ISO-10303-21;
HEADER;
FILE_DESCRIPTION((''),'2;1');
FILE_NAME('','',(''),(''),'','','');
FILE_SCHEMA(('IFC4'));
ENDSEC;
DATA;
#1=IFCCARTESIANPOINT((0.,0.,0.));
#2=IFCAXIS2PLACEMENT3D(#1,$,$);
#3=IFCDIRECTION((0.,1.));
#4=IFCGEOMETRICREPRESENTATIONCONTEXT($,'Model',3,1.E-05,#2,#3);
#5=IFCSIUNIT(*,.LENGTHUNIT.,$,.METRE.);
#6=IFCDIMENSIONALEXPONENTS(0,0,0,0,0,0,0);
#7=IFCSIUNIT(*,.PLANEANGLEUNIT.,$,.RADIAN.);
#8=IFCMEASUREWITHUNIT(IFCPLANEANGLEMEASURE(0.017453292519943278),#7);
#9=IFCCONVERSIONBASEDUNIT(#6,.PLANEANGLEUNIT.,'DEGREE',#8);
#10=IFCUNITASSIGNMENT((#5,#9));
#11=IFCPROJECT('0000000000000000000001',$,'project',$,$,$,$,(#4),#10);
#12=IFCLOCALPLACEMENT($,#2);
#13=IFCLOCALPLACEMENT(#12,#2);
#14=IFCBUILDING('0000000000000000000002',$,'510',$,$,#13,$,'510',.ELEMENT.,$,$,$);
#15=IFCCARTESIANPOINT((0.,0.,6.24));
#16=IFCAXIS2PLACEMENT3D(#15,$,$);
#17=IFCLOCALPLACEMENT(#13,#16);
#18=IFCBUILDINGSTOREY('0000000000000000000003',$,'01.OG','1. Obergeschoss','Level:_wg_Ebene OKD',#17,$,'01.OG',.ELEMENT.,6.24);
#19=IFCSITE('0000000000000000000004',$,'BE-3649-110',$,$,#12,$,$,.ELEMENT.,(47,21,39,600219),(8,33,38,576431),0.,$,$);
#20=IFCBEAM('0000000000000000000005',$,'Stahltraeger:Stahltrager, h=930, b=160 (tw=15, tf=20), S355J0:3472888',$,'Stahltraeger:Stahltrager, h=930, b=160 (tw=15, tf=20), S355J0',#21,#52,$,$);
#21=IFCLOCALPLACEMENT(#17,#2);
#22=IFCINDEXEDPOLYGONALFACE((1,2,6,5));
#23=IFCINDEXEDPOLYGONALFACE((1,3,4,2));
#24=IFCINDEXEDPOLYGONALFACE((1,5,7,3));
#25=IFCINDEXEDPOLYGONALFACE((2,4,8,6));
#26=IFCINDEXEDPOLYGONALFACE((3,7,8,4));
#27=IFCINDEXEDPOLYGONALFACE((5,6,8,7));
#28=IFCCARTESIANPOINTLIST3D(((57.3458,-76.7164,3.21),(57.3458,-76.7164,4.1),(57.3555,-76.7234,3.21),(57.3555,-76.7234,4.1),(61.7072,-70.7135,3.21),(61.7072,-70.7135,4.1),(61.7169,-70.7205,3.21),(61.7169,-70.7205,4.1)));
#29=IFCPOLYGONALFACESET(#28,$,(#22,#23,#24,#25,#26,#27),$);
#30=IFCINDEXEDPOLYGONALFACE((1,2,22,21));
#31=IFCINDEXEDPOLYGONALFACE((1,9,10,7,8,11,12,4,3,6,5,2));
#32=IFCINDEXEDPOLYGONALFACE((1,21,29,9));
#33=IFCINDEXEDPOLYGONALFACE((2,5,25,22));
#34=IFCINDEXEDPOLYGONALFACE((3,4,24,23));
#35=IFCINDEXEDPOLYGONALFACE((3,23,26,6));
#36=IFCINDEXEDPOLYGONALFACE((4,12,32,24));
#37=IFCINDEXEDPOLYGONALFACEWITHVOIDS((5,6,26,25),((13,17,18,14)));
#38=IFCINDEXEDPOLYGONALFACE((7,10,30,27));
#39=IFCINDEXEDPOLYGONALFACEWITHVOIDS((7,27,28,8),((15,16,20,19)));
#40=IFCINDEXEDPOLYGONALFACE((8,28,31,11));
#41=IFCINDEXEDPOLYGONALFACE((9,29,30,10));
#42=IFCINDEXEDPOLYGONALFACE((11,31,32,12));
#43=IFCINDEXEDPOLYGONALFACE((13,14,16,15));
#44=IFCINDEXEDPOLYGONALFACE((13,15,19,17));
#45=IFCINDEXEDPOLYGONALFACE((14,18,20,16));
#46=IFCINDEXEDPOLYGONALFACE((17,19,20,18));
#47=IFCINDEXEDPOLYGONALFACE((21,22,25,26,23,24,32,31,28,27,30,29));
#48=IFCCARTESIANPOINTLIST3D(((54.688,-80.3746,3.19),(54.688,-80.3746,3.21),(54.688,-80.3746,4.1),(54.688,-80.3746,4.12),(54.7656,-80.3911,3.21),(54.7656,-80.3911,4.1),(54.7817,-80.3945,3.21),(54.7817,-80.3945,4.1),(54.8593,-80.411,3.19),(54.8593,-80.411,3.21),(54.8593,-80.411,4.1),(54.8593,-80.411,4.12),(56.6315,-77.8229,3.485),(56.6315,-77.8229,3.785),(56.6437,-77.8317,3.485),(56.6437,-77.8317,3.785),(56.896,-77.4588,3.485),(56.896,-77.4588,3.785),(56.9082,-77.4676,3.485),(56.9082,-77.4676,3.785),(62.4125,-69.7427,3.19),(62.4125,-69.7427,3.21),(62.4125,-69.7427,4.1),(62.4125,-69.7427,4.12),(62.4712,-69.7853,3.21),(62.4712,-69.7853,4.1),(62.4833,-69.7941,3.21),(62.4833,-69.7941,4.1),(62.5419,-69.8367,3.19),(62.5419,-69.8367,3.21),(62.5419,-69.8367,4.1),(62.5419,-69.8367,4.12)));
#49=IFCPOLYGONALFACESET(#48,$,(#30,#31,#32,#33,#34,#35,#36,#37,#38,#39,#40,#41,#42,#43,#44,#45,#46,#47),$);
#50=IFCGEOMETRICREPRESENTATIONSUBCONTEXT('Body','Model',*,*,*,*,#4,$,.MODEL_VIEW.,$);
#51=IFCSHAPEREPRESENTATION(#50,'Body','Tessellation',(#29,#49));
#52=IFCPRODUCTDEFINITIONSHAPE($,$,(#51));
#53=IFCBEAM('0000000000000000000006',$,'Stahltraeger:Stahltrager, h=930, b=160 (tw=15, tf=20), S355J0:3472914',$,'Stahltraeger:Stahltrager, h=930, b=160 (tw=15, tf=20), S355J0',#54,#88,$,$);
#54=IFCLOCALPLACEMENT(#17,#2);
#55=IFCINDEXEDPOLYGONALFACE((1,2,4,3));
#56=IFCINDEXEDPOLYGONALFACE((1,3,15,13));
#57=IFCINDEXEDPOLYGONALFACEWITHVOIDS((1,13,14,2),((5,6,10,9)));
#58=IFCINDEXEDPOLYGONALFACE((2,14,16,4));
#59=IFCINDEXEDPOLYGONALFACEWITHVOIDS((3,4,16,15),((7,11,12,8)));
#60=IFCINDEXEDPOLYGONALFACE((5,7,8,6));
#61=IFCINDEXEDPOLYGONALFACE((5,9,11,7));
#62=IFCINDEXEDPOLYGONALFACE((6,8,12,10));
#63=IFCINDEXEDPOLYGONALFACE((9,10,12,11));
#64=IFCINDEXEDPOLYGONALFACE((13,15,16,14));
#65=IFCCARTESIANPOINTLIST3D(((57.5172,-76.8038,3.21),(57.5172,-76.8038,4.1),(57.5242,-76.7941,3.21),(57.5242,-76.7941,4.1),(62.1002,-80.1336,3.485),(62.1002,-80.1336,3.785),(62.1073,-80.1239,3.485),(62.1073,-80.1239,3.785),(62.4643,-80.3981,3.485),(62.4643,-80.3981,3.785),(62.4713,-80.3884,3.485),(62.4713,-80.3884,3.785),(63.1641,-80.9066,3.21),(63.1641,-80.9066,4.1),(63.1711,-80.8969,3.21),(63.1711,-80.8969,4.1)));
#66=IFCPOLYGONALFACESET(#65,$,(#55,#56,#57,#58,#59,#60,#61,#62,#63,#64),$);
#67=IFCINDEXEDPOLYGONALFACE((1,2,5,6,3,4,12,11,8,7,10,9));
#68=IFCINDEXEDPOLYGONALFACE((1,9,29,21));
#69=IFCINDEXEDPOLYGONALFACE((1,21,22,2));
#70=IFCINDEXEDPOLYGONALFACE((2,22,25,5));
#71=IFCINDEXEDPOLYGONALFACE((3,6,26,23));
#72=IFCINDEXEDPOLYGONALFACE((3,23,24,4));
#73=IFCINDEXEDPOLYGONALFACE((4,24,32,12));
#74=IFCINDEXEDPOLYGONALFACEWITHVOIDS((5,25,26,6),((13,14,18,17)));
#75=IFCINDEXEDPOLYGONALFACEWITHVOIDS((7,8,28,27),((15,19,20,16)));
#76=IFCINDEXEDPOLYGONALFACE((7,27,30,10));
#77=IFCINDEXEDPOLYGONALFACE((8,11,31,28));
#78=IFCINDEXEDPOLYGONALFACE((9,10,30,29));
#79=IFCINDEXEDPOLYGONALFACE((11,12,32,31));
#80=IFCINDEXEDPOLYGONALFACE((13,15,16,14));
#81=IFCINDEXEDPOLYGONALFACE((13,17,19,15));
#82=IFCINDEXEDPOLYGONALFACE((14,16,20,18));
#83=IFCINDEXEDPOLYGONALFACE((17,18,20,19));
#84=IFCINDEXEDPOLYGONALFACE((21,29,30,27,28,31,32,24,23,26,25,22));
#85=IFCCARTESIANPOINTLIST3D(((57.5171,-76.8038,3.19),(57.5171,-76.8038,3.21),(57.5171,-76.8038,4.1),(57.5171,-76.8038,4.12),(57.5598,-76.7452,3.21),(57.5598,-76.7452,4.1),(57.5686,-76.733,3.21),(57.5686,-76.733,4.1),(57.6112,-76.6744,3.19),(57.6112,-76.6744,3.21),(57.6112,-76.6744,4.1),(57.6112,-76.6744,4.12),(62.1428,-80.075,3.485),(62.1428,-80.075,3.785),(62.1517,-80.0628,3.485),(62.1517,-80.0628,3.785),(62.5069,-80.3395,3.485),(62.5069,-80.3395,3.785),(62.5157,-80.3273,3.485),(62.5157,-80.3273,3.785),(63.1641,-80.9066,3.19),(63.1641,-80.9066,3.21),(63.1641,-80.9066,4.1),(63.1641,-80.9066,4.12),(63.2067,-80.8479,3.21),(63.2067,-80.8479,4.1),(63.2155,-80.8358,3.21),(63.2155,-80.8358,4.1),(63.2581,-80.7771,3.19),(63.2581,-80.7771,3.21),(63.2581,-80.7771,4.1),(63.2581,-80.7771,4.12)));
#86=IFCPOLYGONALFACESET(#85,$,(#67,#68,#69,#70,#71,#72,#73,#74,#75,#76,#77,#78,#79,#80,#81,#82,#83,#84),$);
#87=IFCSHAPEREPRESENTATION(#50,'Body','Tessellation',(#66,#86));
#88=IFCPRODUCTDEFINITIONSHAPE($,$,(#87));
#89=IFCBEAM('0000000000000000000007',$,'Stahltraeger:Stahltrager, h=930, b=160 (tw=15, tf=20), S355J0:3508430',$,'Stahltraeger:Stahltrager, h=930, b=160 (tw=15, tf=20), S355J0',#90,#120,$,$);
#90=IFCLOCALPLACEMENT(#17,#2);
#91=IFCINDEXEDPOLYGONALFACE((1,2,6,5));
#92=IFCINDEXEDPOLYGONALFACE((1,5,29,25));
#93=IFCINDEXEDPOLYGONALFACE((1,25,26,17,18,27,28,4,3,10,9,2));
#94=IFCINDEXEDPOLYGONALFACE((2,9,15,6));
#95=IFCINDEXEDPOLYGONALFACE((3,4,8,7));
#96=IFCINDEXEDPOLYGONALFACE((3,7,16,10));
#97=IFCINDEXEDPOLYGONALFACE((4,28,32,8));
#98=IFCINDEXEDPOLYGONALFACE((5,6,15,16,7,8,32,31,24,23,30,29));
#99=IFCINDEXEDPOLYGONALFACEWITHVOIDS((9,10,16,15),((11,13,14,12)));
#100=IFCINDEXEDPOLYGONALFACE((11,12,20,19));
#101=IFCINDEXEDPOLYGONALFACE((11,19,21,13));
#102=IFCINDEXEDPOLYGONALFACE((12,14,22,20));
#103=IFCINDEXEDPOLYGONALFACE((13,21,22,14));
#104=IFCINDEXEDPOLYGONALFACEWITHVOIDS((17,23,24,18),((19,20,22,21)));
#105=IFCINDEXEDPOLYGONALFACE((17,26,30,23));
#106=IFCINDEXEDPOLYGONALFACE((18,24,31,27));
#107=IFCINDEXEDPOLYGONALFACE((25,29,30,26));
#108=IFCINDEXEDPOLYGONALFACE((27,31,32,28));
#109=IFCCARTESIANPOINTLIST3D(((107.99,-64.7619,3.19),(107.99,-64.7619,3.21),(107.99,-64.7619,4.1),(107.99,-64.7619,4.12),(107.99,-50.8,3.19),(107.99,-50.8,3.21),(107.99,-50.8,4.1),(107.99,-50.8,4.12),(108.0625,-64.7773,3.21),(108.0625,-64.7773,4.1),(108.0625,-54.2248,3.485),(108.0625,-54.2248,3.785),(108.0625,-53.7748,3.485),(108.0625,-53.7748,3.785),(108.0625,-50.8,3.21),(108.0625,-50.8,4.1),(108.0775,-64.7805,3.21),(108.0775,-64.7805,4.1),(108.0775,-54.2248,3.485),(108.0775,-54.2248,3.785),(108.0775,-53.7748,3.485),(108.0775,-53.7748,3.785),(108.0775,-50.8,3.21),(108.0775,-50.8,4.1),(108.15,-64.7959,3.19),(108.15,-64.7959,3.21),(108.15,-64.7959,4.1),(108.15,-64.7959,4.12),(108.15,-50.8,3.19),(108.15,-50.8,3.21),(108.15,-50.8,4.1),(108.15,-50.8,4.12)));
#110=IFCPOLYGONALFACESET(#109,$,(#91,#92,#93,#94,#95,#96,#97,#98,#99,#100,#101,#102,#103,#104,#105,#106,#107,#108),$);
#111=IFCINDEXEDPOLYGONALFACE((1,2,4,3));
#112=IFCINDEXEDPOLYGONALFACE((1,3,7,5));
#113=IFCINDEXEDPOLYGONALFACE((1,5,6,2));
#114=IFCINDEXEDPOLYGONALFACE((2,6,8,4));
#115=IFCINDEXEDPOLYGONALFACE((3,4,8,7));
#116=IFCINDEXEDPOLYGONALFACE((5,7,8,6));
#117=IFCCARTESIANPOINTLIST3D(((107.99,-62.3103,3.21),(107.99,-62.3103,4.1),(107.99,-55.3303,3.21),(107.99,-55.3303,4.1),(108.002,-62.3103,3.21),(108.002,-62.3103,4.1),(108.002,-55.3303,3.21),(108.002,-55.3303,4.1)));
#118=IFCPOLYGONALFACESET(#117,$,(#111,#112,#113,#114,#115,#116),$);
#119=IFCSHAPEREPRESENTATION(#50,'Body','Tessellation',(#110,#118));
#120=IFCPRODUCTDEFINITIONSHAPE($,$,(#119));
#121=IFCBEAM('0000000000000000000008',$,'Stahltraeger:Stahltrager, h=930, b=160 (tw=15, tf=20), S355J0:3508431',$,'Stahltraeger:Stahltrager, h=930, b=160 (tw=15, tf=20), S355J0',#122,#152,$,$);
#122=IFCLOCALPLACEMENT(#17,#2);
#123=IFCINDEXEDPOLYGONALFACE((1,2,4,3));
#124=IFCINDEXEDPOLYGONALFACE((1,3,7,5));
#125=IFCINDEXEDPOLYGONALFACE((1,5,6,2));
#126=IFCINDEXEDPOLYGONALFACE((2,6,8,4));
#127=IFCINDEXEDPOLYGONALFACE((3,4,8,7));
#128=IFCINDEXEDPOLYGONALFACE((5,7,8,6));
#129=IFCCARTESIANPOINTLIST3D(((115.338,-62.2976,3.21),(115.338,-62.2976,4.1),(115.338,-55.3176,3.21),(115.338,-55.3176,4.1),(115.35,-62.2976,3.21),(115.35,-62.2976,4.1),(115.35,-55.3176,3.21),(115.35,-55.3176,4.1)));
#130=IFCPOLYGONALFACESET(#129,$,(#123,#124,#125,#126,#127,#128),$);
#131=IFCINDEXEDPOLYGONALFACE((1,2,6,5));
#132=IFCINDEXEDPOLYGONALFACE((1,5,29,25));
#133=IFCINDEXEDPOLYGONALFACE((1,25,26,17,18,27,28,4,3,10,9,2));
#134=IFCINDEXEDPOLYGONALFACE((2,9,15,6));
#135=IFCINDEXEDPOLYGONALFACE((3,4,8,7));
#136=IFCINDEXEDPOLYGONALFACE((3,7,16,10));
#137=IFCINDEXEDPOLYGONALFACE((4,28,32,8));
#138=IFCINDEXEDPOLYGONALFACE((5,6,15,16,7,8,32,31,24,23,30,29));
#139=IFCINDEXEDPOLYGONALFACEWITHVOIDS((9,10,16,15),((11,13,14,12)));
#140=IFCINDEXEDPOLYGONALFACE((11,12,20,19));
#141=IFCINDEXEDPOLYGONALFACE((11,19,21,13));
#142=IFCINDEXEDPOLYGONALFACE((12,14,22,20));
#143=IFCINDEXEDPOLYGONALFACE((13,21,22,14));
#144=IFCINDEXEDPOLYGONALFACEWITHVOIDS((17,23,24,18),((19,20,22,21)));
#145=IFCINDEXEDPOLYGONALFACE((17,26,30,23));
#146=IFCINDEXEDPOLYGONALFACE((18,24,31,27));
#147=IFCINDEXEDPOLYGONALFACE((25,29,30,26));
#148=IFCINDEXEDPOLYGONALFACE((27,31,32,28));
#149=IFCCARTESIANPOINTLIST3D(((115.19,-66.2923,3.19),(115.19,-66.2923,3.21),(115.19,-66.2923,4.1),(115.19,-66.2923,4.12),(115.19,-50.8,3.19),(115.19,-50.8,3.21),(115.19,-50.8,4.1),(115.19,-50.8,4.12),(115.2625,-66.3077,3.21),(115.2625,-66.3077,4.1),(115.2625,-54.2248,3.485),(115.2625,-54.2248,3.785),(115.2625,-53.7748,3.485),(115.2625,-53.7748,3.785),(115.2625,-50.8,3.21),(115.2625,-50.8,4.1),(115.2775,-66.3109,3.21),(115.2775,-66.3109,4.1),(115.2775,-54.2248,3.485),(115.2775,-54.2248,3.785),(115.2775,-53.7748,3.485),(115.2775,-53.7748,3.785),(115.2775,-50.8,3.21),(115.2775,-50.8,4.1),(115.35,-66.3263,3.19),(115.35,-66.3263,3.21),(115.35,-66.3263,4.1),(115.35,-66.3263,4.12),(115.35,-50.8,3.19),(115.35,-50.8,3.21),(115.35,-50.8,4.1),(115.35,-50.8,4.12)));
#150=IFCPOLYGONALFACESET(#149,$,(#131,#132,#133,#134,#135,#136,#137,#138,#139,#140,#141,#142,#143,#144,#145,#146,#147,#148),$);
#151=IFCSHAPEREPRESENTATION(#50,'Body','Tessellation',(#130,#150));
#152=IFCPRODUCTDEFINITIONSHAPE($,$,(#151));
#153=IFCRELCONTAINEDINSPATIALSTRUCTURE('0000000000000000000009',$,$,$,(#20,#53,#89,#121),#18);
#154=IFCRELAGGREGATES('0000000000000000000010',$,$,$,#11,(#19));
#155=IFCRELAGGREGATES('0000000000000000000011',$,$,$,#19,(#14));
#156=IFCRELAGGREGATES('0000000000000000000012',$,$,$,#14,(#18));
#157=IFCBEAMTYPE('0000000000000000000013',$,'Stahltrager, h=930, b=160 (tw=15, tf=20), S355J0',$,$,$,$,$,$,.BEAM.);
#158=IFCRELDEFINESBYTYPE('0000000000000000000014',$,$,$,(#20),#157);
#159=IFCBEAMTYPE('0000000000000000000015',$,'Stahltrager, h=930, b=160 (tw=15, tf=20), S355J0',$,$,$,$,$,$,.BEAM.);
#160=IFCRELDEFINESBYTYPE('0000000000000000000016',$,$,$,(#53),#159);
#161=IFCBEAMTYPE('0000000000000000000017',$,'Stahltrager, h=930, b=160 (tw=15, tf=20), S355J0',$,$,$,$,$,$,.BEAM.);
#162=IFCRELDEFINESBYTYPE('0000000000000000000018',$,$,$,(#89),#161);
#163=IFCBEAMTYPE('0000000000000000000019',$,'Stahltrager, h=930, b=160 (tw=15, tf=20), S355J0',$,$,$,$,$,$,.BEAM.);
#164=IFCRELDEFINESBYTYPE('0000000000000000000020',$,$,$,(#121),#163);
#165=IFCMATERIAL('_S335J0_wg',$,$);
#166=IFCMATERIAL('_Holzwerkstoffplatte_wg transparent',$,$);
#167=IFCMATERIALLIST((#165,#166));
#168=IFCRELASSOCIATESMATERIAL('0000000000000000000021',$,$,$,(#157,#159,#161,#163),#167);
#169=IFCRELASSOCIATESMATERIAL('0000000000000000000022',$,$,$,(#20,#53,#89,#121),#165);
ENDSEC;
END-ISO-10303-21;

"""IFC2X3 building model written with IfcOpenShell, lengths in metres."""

from ifc_helpers import new_model, entity, si_unit, converted_unit, direction, frame, frame_2d, origin, place, context, subcontext, project, spatial, rectangle, i_section, extrude, boolean, clip, halfspace, source, transform, mapped, material, material_list, type_object, type_shapes, element, save


model = new_model("IFC2X3")

# Units and contexts
model_context = context("Model", 3, precision=1e-05, world=origin(), true_north=direction((0.0, 1.0)))
body_context = subcontext(model_context, "Body", "Model", "MODEL_VIEW")
ifc_project = project(units=[si_unit("LENGTHUNIT", "METRE"), converted_unit("PLANEANGLEUNIT", "DEGREE", entity("IfcPlaneAngleMeasure", 0.017453292519943278), si_unit("PLANEANGLEUNIT", "RADIAN"), dimensions=[0, 0, 0, 0, 0, 0, 0])], contexts=[model_context])

# Site, building, storey
site_placement = place(None, origin())
site = spatial("IfcSite", under=ifc_project, at=site_placement, Name="BE-3649-110", CompositionType="ELEMENT", RefLatitude=(47, 21, 39, 600219), RefLongitude=(8, 33, 38, 576431), RefElevation=0.0)
building_placement = place(site_placement, origin())
building = spatial("IfcBuilding", under=site, at=building_placement, Name="510", LongName="510", CompositionType="ELEMENT")
storey_placement = place(building_placement, frame((0.0, 0.0, 6.24)))
storey = spatial("IfcBuildingStorey", under=building, at=storey_placement, Name="01.OG", Description="1. Obergeschoss", ObjectType="Level:_wg_Ebene OKD", LongName="01.OG", CompositionType="ELEMENT", Elevation=6.24)

# Beams
ifc_material_1 = material(Name="_S335J0_wg")
ifc_material_2 = material(Name="_Holzwerkstoffplatte_wg transparent")
ifc_material_list = material_list([ifc_material_1, ifc_material_2])
beam_type_1 = type_object("IfcBeamType", Name="Stahltrager, h=930, b=160 (tw=15, tf=20), S355J0", PredefinedType="BEAM", material=ifc_material_list)
shared_shape_1 = source(origin(), body_context, "Body", "SweptSolid", [
    extrude(rectangle(XDim=0.89, YDim=0.012, at=frame_2d((0.0, 0.0), x_axis=(1.0, 0.0))), frame((61.712, -70.717, 9.895), z_axis=(-0.587785, -0.809017, 0.0), x_axis=(0.0, 0.0, -1.0)), (0.0, 0.0, 1.0), 7.42),
    boolean("DIFFERENCE", clip(extrude(i_section(OverallWidth=0.16, OverallDepth=0.93, WebThickness=0.015, FlangeThickness=0.02, at=frame_2d((0.0, 0.0), x_axis=(0.0, 1.0))), frame((62.4772, -69.7897, 9.895), z_axis=(-0.587785, -0.809017, 0.0), x_axis=(0.0, 0.0, -1.0)), (0.0, 0.0, 1.0), 13.1418), halfspace(frame((55.5292, -80.5534, -0.22), z_axis=(-0.207912, -0.978148, 0.0), x_axis=(-0.978148, 0.207912, 0.0)), False)), extrude(rectangle(XDim=0.3, YDim=0.45, at=frame_2d((0.0, 0.0), x_axis=(0.0, 1.0))), frame((56.7759, -77.6497, 9.875), z_axis=(-0.809017, 0.587785, 0.0), x_axis=(0.587785, 0.809017, 0.0)), (0.0, 0.0, 1.0), 0.015)),
])
type_shapes(beam_type_1, [shared_shape_1])
beam_1_placement = place(storey_placement, frame((0.0, 0.0, -6.24)))
element("IfcBeam", 1, at=beam_1_placement, inside=storey, type_object=beam_type_1, material=ifc_material_1, Name="Stahltraeger:Stahltrager, h=930, b=160 (tw=15, tf=20), S355J0:3472888", ObjectType="Stahltraeger:Stahltrager, h=930, b=160 (tw=15, tf=20), S355J0", context=body_context, shape_type="MappedRepresentation", body=[
    mapped(shared_shape_1, transform((0.0, 0.0, 0.0), scale=1.0)),
])
beam_type_2 = type_object("IfcBeamType", Name="Stahltrager, h=930, b=160 (tw=15, tf=20), S355J0", PredefinedType="BEAM", material=ifc_material_list)
shared_shape_2 = source(origin(), body_context, "Body", "SweptSolid", [
    boolean("DIFFERENCE", extrude(rectangle(XDim=0.89, YDim=0.012, at=frame_2d((0.0, 0.0), x_axis=(0.0, 1.0))), frame((57.5207, -76.799, 9.895), z_axis=(0.809017, -0.587785, 0.0), x_axis=(0.587785, 0.809017, 0.0)), (0.0, 0.0, 1.0), 6.98), extrude(rectangle(XDim=0.3, YDim=0.45, at=frame_2d((0.0, 0.0), x_axis=(0.0, 1.0))), frame((62.2823, -80.2659, 9.875), z_axis=(0.587785, 0.809017, 0.0), x_axis=(0.809017, -0.587785, 0.0)), (0.0, 0.0, 1.0), 0.012)),
    boolean("DIFFERENCE", extrude(i_section(OverallWidth=0.16, OverallDepth=0.93, WebThickness=0.015, FlangeThickness=0.02, at=frame_2d((0.0, 0.0), x_axis=(0.0, 1.0))), frame((57.5642, -76.7391, 9.895), z_axis=(0.809017, -0.587785, 0.0), x_axis=(0.0, 0.0, -1.0)), (0.0, 0.0, 1.0), 6.98), extrude(rectangle(XDim=0.3, YDim=0.45, at=frame_2d((0.0, 0.0), x_axis=(0.0, 1.0))), frame((62.3249, -80.2072, 9.875), z_axis=(0.587785, 0.809017, 0.0), x_axis=(0.809017, -0.587785, 0.0)), (0.0, 0.0, 1.0), 0.015)),
])
type_shapes(beam_type_2, [shared_shape_2])
beam_2_placement = place(storey_placement, frame((0.0, 0.0, -6.24)))
element("IfcBeam", 2, at=beam_2_placement, inside=storey, type_object=beam_type_2, material=ifc_material_1, Name="Stahltraeger:Stahltrager, h=930, b=160 (tw=15, tf=20), S355J0:3472914", ObjectType="Stahltraeger:Stahltrager, h=930, b=160 (tw=15, tf=20), S355J0", context=body_context, shape_type="MappedRepresentation", body=[
    mapped(shared_shape_2, transform((0.0, 0.0, 0.0), scale=1.0)),
])
beam_type_3 = type_object("IfcBeamType", Name="Stahltrager, h=930, b=160 (tw=15, tf=20), S355J0", PredefinedType="BEAM", material=ifc_material_list)
shared_shape_3 = source(origin(), body_context, "Body", "SweptSolid", [
    boolean("DIFFERENCE", clip(extrude(i_section(OverallWidth=0.16, OverallDepth=0.93, WebThickness=0.015, FlangeThickness=0.02, at=frame_2d((0.0, 0.0), x_axis=(1.0, 0.0))), frame((108.07, -50.8, 9.895), z_axis=(0.0, -1.0, 0.0), x_axis=(-1.0, 0.0, 0.0)), (0.0, 0.0, 1.0), 13.9959), halfspace(frame((108.39, -64.8469, -0.22), z_axis=(-0.207912, -0.978148, 0.0), x_axis=(-0.978148, 0.207912, 0.0)), False)), extrude(rectangle(XDim=0.3, YDim=0.45, at=frame_2d((0.0, 0.0), x_axis=(0.0, 1.0))), frame((108.0625, -53.9998, 9.875), z_axis=(1.0, 0.0, 0.0), x_axis=(0.0, -1.0, 0.0)), (0.0, 0.0, 1.0), 0.015)),
    extrude(rectangle(XDim=0.89, YDim=0.012, at=frame_2d((0.0, 0.0), x_axis=(0.0, 1.0))), frame((107.996, -55.3303, 9.895), z_axis=(0.0, -1.0, 0.0), x_axis=(-1.0, 0.0, 0.0)), (0.0, 0.0, 1.0), 6.98),
])
type_shapes(beam_type_3, [shared_shape_3])
beam_3_placement = place(storey_placement, frame((0.0, 0.0, -6.24)))
element("IfcBeam", 3, at=beam_3_placement, inside=storey, type_object=beam_type_3, material=ifc_material_1, Name="Stahltraeger:Stahltrager, h=930, b=160 (tw=15, tf=20), S355J0:3508430", ObjectType="Stahltraeger:Stahltrager, h=930, b=160 (tw=15, tf=20), S355J0", context=body_context, shape_type="MappedRepresentation", body=[
    mapped(shared_shape_3, transform((0.0, 0.0, 0.0), scale=1.0)),
])
beam_type_4 = type_object("IfcBeamType", Name="Stahltrager, h=930, b=160 (tw=15, tf=20), S355J0", PredefinedType="BEAM", material=ifc_material_list)
shared_shape_4 = source(origin(), body_context, "Body", "SweptSolid", [
    extrude(rectangle(XDim=0.89, YDim=0.012, at=frame_2d((0.0, 0.0), x_axis=(0.0, 1.0))), frame((115.344, -55.3176, 9.895), z_axis=(0.0, -1.0, 0.0), x_axis=(-1.0, 0.0, 0.0)), (0.0, 0.0, 1.0), 6.98),
    boolean("DIFFERENCE", clip(extrude(i_section(OverallWidth=0.16, OverallDepth=0.93, WebThickness=0.015, FlangeThickness=0.02, at=frame_2d((0.0, 0.0), x_axis=(1.0, 0.0))), frame((115.27, -50.8, 9.895), z_axis=(0.0, -1.0, 0.0), x_axis=(-1.0, 0.0, 0.0)), (0.0, 0.0, 1.0), 15.5263), halfspace(frame((115.7261, -66.4062, -0.22), z_axis=(-0.207912, -0.978148, 0.0), x_axis=(-0.978148, 0.207912, 0.0)), False)), extrude(rectangle(XDim=0.3, YDim=0.45, at=frame_2d((0.0, 0.0), x_axis=(0.0, 1.0))), frame((115.2625, -53.9998, 9.875), z_axis=(1.0, 0.0, 0.0), x_axis=(0.0, -1.0, 0.0)), (0.0, 0.0, 1.0), 0.015)),
])
type_shapes(beam_type_4, [shared_shape_4])
beam_4_placement = place(storey_placement, frame((0.0, 0.0, -6.24)))
element("IfcBeam", 4, at=beam_4_placement, inside=storey, type_object=beam_type_4, material=ifc_material_1, Name="Stahltraeger:Stahltrager, h=930, b=160 (tw=15, tf=20), S355J0:3508431", ObjectType="Stahltraeger:Stahltrager, h=930, b=160 (tw=15, tf=20), S355J0", context=body_context, shape_type="MappedRepresentation", body=[
    mapped(shared_shape_4, transform((0.0, 0.0, 0.0), scale=1.0)),
])

save(model, "model.ifc")
